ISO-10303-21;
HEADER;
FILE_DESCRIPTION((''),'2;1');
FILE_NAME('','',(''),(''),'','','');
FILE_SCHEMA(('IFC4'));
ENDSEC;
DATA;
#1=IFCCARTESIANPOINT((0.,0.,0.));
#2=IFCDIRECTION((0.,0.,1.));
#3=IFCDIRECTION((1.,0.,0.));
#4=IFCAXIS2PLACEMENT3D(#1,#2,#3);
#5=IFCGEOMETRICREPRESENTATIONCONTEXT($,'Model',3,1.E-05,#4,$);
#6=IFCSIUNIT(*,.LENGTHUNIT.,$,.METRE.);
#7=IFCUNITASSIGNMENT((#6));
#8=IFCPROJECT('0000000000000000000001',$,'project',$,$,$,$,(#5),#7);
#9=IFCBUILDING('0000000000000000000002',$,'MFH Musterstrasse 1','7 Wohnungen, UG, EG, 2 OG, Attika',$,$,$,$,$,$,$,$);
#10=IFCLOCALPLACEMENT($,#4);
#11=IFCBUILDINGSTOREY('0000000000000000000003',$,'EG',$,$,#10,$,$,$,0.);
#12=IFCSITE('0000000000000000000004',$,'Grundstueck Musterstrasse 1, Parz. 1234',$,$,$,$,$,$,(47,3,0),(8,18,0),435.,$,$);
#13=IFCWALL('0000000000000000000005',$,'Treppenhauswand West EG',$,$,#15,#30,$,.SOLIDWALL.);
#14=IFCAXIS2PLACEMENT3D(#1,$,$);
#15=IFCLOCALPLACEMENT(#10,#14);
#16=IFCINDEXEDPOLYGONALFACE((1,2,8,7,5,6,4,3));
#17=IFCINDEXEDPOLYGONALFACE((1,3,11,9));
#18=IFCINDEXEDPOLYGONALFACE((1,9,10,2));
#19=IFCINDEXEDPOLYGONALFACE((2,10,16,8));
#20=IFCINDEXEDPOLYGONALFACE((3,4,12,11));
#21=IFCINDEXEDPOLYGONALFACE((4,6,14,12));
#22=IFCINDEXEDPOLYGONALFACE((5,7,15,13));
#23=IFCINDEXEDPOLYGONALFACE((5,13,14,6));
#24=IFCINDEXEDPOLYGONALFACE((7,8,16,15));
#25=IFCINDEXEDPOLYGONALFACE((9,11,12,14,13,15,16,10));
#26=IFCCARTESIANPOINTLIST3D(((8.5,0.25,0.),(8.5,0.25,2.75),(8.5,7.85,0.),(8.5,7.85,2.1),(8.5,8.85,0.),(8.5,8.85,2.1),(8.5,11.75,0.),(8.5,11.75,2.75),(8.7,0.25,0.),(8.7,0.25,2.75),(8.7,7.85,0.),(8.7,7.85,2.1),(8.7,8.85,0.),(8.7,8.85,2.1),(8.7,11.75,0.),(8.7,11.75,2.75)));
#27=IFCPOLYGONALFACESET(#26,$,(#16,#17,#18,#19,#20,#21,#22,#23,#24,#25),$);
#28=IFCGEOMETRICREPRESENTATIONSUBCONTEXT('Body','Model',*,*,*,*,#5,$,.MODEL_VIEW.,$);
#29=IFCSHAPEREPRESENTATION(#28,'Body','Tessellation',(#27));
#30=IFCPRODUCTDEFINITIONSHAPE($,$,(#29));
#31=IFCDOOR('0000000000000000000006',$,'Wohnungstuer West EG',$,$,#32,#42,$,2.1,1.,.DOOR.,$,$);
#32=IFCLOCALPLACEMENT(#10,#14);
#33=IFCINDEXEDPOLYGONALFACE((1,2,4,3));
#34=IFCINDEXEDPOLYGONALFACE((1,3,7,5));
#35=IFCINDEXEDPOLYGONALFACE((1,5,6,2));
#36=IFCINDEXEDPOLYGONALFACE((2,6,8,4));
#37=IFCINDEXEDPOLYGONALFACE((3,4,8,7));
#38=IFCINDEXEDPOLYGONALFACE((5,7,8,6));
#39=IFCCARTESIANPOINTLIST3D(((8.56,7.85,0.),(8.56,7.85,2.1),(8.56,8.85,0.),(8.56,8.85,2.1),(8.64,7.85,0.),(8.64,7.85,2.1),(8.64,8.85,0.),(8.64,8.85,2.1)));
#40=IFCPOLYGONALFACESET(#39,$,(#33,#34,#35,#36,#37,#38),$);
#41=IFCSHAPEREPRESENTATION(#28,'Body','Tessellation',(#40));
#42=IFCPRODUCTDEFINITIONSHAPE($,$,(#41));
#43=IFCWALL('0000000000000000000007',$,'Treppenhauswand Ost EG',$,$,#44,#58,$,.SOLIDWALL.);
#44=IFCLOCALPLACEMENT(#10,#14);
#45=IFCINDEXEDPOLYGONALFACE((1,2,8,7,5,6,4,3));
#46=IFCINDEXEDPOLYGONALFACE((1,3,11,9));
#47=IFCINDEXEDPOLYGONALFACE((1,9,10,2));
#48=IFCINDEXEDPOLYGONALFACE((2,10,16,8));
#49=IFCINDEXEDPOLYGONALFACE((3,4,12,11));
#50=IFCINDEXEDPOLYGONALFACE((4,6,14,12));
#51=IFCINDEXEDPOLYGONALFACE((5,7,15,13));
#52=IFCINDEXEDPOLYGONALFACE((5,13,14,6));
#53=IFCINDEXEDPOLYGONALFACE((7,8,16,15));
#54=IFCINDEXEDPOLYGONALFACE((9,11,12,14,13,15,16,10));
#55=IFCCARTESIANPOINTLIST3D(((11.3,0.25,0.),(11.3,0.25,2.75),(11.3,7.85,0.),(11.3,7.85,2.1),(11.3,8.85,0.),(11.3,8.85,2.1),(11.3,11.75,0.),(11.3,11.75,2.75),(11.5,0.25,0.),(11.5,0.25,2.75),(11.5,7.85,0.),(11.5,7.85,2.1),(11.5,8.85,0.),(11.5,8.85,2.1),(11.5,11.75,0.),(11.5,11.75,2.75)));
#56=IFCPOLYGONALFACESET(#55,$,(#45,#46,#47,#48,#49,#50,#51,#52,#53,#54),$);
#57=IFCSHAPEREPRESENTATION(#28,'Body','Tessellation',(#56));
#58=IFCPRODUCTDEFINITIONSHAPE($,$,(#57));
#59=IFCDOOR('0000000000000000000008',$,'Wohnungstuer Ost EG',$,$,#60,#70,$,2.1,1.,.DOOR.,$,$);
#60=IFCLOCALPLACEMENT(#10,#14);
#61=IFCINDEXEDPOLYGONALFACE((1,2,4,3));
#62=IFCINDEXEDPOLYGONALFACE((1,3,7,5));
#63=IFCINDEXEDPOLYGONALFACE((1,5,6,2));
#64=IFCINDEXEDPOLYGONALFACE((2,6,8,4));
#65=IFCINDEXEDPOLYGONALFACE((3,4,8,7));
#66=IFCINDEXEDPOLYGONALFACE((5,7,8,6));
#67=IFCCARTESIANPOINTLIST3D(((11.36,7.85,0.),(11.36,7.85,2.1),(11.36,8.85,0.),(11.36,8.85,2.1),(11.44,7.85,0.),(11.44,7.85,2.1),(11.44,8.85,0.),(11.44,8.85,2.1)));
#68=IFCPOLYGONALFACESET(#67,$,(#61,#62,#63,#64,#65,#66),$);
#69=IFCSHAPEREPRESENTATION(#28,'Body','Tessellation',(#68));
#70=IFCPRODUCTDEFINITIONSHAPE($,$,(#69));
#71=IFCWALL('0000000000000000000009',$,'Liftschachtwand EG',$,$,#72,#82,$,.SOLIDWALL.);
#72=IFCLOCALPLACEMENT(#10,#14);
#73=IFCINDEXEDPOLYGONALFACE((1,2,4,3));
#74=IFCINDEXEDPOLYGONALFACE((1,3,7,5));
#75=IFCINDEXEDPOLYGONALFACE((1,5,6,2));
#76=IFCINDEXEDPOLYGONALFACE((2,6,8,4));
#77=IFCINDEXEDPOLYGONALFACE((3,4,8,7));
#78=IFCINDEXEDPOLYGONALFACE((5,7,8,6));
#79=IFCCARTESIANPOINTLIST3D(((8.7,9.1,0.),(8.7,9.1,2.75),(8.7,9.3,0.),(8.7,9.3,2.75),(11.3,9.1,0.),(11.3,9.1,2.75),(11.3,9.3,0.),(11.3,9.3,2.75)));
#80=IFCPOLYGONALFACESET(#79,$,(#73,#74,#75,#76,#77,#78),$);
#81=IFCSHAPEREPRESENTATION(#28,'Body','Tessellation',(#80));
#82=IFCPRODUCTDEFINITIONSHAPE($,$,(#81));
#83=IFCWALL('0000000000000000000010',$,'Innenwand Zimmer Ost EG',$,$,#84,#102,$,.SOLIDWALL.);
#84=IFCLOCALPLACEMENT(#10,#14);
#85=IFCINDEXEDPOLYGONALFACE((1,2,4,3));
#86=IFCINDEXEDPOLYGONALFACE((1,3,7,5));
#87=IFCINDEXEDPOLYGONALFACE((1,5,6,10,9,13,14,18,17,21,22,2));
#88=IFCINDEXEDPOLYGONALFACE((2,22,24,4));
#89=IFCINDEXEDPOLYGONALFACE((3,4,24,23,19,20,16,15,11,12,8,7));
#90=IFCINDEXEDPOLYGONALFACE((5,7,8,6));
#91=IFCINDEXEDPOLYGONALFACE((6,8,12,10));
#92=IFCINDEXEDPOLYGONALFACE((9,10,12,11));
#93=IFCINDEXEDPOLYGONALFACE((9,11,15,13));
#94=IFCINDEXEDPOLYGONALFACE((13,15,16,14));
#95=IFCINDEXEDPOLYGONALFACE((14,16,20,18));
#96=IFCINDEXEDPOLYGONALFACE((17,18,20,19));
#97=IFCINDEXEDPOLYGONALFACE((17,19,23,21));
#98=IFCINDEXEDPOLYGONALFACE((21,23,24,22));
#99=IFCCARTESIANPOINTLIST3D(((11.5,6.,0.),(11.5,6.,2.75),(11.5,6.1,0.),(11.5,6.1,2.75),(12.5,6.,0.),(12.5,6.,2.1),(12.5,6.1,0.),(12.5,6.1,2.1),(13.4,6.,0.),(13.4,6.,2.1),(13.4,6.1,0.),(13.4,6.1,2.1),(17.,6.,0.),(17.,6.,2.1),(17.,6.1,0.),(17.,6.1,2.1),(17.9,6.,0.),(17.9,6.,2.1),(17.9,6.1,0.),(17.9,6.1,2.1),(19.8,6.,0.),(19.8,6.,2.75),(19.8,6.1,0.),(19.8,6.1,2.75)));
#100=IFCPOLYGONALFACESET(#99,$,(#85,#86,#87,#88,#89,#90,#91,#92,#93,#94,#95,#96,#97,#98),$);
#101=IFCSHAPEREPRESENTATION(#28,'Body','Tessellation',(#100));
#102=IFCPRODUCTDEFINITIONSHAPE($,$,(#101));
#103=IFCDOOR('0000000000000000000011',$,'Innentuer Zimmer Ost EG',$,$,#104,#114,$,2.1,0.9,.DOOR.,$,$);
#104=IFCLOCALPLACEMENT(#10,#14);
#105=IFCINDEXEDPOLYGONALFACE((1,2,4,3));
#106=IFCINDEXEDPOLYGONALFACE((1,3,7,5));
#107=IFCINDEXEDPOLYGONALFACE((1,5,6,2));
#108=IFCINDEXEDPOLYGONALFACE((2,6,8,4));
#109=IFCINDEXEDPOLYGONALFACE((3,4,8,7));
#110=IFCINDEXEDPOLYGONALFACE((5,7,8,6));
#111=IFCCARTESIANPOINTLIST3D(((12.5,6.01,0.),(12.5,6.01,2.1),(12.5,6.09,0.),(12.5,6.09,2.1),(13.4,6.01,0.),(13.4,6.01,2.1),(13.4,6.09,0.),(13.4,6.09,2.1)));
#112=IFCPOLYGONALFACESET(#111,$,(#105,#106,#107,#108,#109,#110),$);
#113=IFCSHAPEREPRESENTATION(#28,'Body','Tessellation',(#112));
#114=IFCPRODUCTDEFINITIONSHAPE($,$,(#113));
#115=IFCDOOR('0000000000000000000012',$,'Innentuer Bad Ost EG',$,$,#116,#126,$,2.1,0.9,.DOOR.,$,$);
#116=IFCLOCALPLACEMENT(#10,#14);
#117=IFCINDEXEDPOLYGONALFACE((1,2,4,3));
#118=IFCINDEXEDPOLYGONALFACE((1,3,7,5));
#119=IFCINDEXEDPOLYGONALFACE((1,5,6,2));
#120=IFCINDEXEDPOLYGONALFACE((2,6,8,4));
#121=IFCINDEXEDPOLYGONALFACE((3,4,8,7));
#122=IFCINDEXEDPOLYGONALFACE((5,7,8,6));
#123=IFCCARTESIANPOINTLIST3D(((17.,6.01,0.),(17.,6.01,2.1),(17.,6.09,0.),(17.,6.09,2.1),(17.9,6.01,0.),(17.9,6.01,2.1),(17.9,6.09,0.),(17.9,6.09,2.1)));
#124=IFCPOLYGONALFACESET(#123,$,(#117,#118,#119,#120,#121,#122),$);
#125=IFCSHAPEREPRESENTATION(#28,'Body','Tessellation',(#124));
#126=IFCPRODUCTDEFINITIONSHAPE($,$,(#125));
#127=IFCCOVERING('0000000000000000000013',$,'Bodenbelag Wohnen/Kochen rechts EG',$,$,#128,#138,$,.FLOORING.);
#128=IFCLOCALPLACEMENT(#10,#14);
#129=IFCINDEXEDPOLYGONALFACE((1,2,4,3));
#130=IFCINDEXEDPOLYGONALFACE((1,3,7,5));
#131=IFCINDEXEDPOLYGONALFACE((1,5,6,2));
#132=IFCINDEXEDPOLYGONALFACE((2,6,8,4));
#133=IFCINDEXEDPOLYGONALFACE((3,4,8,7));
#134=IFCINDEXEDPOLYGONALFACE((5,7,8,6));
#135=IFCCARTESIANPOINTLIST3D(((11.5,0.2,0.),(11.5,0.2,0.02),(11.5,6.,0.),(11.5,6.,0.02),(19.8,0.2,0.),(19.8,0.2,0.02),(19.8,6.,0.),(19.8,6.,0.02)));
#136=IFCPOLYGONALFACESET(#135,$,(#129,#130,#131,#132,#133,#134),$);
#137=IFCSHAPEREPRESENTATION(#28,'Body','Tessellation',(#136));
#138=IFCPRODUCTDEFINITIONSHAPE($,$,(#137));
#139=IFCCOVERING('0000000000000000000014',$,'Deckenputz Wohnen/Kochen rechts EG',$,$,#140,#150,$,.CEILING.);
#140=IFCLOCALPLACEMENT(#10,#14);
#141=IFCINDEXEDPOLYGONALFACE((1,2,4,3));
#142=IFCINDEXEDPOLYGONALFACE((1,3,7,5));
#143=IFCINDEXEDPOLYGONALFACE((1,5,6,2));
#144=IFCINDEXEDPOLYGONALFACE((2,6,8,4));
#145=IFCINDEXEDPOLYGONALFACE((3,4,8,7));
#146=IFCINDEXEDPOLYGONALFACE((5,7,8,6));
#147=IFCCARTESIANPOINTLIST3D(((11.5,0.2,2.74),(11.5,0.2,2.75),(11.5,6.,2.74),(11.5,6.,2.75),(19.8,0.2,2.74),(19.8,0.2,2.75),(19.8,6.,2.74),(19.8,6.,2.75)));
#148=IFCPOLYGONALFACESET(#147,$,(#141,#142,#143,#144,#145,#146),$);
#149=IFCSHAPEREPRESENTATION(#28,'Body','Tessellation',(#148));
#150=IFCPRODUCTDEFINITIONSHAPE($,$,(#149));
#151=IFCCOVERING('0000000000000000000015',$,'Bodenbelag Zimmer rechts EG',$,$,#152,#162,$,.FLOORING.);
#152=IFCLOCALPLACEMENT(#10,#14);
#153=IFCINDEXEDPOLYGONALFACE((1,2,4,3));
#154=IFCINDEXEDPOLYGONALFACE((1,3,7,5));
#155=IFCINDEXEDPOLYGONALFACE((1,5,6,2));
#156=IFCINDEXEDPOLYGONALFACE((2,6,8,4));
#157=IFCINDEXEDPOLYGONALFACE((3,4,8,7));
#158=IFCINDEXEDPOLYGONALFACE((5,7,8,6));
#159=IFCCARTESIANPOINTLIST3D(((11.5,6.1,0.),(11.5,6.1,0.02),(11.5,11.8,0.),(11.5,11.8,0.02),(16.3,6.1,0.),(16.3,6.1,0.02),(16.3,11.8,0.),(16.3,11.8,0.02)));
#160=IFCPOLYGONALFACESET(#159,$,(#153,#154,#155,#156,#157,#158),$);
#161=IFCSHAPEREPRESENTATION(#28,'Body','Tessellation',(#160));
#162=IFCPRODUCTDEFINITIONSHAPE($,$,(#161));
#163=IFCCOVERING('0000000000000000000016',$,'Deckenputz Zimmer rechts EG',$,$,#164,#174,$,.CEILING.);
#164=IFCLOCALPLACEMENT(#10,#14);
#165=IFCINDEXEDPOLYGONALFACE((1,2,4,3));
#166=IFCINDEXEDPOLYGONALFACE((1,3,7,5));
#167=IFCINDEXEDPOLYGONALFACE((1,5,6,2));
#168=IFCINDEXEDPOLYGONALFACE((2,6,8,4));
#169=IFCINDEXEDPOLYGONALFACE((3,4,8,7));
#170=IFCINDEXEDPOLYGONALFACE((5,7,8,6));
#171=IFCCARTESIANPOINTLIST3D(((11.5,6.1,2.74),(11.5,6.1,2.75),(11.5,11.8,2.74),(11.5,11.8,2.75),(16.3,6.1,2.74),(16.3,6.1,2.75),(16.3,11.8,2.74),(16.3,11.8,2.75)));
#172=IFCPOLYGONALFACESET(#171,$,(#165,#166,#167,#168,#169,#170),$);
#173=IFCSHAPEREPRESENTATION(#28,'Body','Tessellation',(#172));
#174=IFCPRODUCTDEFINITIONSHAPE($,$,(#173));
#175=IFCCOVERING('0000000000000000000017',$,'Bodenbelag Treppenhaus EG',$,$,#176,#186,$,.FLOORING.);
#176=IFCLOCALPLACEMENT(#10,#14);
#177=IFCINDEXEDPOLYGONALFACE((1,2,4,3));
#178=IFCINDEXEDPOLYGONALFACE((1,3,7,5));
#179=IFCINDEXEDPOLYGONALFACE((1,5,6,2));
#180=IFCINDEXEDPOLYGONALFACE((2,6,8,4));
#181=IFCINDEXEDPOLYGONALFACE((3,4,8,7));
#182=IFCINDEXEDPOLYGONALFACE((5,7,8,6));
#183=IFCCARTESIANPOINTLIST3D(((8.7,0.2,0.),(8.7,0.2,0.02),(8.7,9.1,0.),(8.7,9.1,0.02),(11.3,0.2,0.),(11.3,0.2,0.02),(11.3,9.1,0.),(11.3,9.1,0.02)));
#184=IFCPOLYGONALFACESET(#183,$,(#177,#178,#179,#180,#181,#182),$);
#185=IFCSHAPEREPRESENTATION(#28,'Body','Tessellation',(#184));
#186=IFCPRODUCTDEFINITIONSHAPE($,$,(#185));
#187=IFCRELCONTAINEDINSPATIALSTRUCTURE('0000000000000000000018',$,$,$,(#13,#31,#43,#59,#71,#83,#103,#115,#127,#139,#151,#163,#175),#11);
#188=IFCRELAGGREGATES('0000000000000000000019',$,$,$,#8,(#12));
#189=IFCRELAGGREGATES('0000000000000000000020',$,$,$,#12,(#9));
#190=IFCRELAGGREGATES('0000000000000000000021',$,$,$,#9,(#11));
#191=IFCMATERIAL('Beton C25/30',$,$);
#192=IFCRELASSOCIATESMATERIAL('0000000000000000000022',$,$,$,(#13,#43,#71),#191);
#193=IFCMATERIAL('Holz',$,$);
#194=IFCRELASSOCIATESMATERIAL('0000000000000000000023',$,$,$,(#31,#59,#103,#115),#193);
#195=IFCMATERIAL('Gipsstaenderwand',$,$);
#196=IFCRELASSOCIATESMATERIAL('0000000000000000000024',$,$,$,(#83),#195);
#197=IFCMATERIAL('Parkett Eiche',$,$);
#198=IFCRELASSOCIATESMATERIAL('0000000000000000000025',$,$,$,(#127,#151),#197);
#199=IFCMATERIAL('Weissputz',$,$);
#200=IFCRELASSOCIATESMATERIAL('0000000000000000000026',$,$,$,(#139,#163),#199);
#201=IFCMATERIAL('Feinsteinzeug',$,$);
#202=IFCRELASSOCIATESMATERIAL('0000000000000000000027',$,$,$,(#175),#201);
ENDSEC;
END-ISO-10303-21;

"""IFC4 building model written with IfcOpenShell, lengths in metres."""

from ifc_helpers import new_model, si_unit, frame, frame_2d, origin_with_axes, place, context, subcontext, project, spatial, rectangle, extrude, material, element, fill, save


model = new_model("IFC4")

# Units and contexts
model_context = context("Model", 3, precision=1e-05, world=origin_with_axes())
body_context = subcontext(model_context, "Body", "Model", "MODEL_VIEW")
ifc_project = project(units=[si_unit("LENGTHUNIT", "METRE")], contexts=[model_context])

# Site, building, storey
site = spatial("IfcSite", under=ifc_project, Name="Grundstueck Musterstrasse 1, Parz. 1234", RefLatitude=(47, 3, 0), RefLongitude=(8, 18, 0), RefElevation=435.0)
building = spatial("IfcBuilding", under=site, Name="MFH Musterstrasse 1", Description="7 Wohnungen, UG, EG, 2 OG, Attika")
storey_placement = place(None, origin_with_axes())
storey = spatial("IfcBuildingStorey", under=building, at=storey_placement, Name="EG", Elevation=0.0)

# Walls, openings, doors
ifc_material_1 = material(Name="Beton C25/30")
wall_1_placement = place(storey_placement, frame((8.5, 0.25, 0.0), z_axis=(0.0, 0.0, 1.0), x_axis=(1.0, 0.0, 0.0)))
wall_1 = element("IfcWall", 1, at=wall_1_placement, inside=storey, material=ifc_material_1, Name="Treppenhauswand West EG", PredefinedType="SOLIDWALL", context=body_context, shape_type="SweptSolid", body=[
    extrude(rectangle(XDim=0.2, YDim=11.5, at=frame_2d((0.1, 5.75))), origin_with_axes(), (0.0, 0.0, 1.0), 2.75),
])
opening_1_placement = place(wall_1_placement, frame((-0.01, 7.6, 0.0), z_axis=(0.0, 0.0, 1.0), x_axis=(1.0, 0.0, 0.0)))
opening_1 = element("IfcOpeningElement", 2, at=opening_1_placement, cuts=wall_1, context=body_context, shape_type="SweptSolid", body=[
    extrude(rectangle(XDim=0.22, YDim=1.0, at=frame_2d((0.11, 0.5))), origin_with_axes(), (0.0, 0.0, 1.0), 2.1),
])
ifc_material_2 = material(Name="Holz")
door_1_placement = place(storey_placement, frame((8.56, 7.85, 0.0), z_axis=(0.0, 0.0, 1.0), x_axis=(1.0, 0.0, 0.0)))
door_1 = element("IfcDoor", 3, at=door_1_placement, inside=storey, material=ifc_material_2, Name="Wohnungstuer West EG", OverallHeight=2.1, OverallWidth=1.0, PredefinedType="DOOR", context=body_context, shape_type="SweptSolid", body=[
    extrude(rectangle(XDim=0.08, YDim=1.0, at=frame_2d((0.04, 0.5))), origin_with_axes(), (0.0, 0.0, 1.0), 2.1),
])
fill(opening_1, door_1)
wall_2_placement = place(storey_placement, frame((11.3, 0.25, 0.0), z_axis=(0.0, 0.0, 1.0), x_axis=(1.0, 0.0, 0.0)))
wall_2 = element("IfcWall", 4, at=wall_2_placement, inside=storey, material=ifc_material_1, Name="Treppenhauswand Ost EG", PredefinedType="SOLIDWALL", context=body_context, shape_type="SweptSolid", body=[
    extrude(rectangle(XDim=0.2, YDim=11.5, at=frame_2d((0.1, 5.75))), origin_with_axes(), (0.0, 0.0, 1.0), 2.75),
])
opening_2_placement = place(wall_2_placement, frame((-0.01, 7.6, 0.0), z_axis=(0.0, 0.0, 1.0), x_axis=(1.0, 0.0, 0.0)))
opening_2 = element("IfcOpeningElement", 5, at=opening_2_placement, cuts=wall_2, context=body_context, shape_type="SweptSolid", body=[
    extrude(rectangle(XDim=0.22, YDim=1.0, at=frame_2d((0.11, 0.5))), origin_with_axes(), (0.0, 0.0, 1.0), 2.1),
])
door_2_placement = place(storey_placement, frame((11.36, 7.85, 0.0), z_axis=(0.0, 0.0, 1.0), x_axis=(1.0, 0.0, 0.0)))
door_2 = element("IfcDoor", 6, at=door_2_placement, inside=storey, material=ifc_material_2, Name="Wohnungstuer Ost EG", OverallHeight=2.1, OverallWidth=1.0, PredefinedType="DOOR", context=body_context, shape_type="SweptSolid", body=[
    extrude(rectangle(XDim=0.08, YDim=1.0, at=frame_2d((0.04, 0.5))), origin_with_axes(), (0.0, 0.0, 1.0), 2.1),
])
fill(opening_2, door_2)

# Wall
wall_3_placement = place(storey_placement, frame((8.7, 9.1, 0.0), z_axis=(0.0, 0.0, 1.0), x_axis=(1.0, 0.0, 0.0)))
element("IfcWall", 7, at=wall_3_placement, inside=storey, material=ifc_material_1, Name="Liftschachtwand EG", PredefinedType="SOLIDWALL", context=body_context, shape_type="SweptSolid", body=[
    extrude(rectangle(XDim=2.6, YDim=0.2, at=frame_2d((1.3, 0.1))), origin_with_axes(), (0.0, 0.0, 1.0), 2.75),
])

# Wall, openings, doors
ifc_material_3 = material(Name="Gipsstaenderwand")
wall_4_placement = place(storey_placement, frame((11.5, 6.0, 0.0), z_axis=(0.0, 0.0, 1.0), x_axis=(1.0, 0.0, 0.0)))
wall_4 = element("IfcWall", 8, at=wall_4_placement, inside=storey, material=ifc_material_3, Name="Innenwand Zimmer Ost EG", PredefinedType="SOLIDWALL", context=body_context, shape_type="SweptSolid", body=[
    extrude(rectangle(XDim=8.3, YDim=0.1, at=frame_2d((4.15, 0.05))), origin_with_axes(), (0.0, 0.0, 1.0), 2.75),
])
opening_3_placement = place(wall_4_placement, frame((1.0, -0.01, 0.0), z_axis=(0.0, 0.0, 1.0), x_axis=(1.0, 0.0, 0.0)))
opening_3 = element("IfcOpeningElement", 9, at=opening_3_placement, cuts=wall_4, context=body_context, shape_type="SweptSolid", body=[
    extrude(rectangle(XDim=0.9, YDim=0.12, at=frame_2d((0.45, 0.06))), origin_with_axes(), (0.0, 0.0, 1.0), 2.1),
])
opening_4_placement = place(wall_4_placement, frame((5.5, -0.01, 0.0), z_axis=(0.0, 0.0, 1.0), x_axis=(1.0, 0.0, 0.0)))
opening_4 = element("IfcOpeningElement", 10, at=opening_4_placement, cuts=wall_4, context=body_context, shape_type="SweptSolid", body=[
    extrude(rectangle(XDim=0.9, YDim=0.12, at=frame_2d((0.45, 0.06))), origin_with_axes(), (0.0, 0.0, 1.0), 2.1),
])
door_3_placement = place(storey_placement, frame((12.5, 6.01, 0.0), z_axis=(0.0, 0.0, 1.0), x_axis=(1.0, 0.0, 0.0)))
door_3 = element("IfcDoor", 11, at=door_3_placement, inside=storey, material=ifc_material_2, Name="Innentuer Zimmer Ost EG", OverallHeight=2.1, OverallWidth=0.9, PredefinedType="DOOR", context=body_context, shape_type="SweptSolid", body=[
    extrude(rectangle(XDim=0.9, YDim=0.08, at=frame_2d((0.45, 0.04))), origin_with_axes(), (0.0, 0.0, 1.0), 2.1),
])
fill(opening_3, door_3)
door_4_placement = place(storey_placement, frame((17.0, 6.01, 0.0), z_axis=(0.0, 0.0, 1.0), x_axis=(1.0, 0.0, 0.0)))
door_4 = element("IfcDoor", 12, at=door_4_placement, inside=storey, material=ifc_material_2, Name="Innentuer Bad Ost EG", OverallHeight=2.1, OverallWidth=0.9, PredefinedType="DOOR", context=body_context, shape_type="SweptSolid", body=[
    extrude(rectangle(XDim=0.9, YDim=0.08, at=frame_2d((0.45, 0.04))), origin_with_axes(), (0.0, 0.0, 1.0), 2.1),
])
fill(opening_4, door_4)

# Coverings
ifc_material_4 = material(Name="Parkett Eiche")
covering_1_placement = place(storey_placement, frame((11.5, 0.2, 0.0), z_axis=(0.0, 0.0, 1.0), x_axis=(1.0, 0.0, 0.0)))
element("IfcCovering", 13, at=covering_1_placement, inside=storey, material=ifc_material_4, Name="Bodenbelag Wohnen/Kochen rechts EG", PredefinedType="FLOORING", context=body_context, shape_type="SweptSolid", body=[
    extrude(rectangle(XDim=8.3, YDim=5.8, at=frame_2d((4.15, 2.9))), origin_with_axes(), (0.0, 0.0, 1.0), 0.02),
])
ifc_material_5 = material(Name="Weissputz")
covering_2_placement = place(storey_placement, frame((11.5, 0.2, 2.74), z_axis=(0.0, 0.0, 1.0), x_axis=(1.0, 0.0, 0.0)))
element("IfcCovering", 14, at=covering_2_placement, inside=storey, material=ifc_material_5, Name="Deckenputz Wohnen/Kochen rechts EG", PredefinedType="CEILING", context=body_context, shape_type="SweptSolid", body=[
    extrude(rectangle(XDim=8.3, YDim=5.8, at=frame_2d((4.15, 2.9))), origin_with_axes(), (0.0, 0.0, 1.0), 0.01),
])
covering_3_placement = place(storey_placement, frame((11.5, 6.1, 0.0), z_axis=(0.0, 0.0, 1.0), x_axis=(1.0, 0.0, 0.0)))
element("IfcCovering", 15, at=covering_3_placement, inside=storey, material=ifc_material_4, Name="Bodenbelag Zimmer rechts EG", PredefinedType="FLOORING", context=body_context, shape_type="SweptSolid", body=[
    extrude(rectangle(XDim=4.8, YDim=5.7, at=frame_2d((2.4, 2.85))), origin_with_axes(), (0.0, 0.0, 1.0), 0.02),
])
covering_4_placement = place(storey_placement, frame((11.5, 6.1, 2.74), z_axis=(0.0, 0.0, 1.0), x_axis=(1.0, 0.0, 0.0)))
element("IfcCovering", 16, at=covering_4_placement, inside=storey, material=ifc_material_5, Name="Deckenputz Zimmer rechts EG", PredefinedType="CEILING", context=body_context, shape_type="SweptSolid", body=[
    extrude(rectangle(XDim=4.8, YDim=5.7, at=frame_2d((2.4, 2.85))), origin_with_axes(), (0.0, 0.0, 1.0), 0.01),
])
ifc_material_6 = material(Name="Feinsteinzeug")
covering_5_placement = place(storey_placement, frame((8.7, 0.2, 0.0), z_axis=(0.0, 0.0, 1.0), x_axis=(1.0, 0.0, 0.0)))
element("IfcCovering", 17, at=covering_5_placement, inside=storey, material=ifc_material_6, Name="Bodenbelag Treppenhaus EG", PredefinedType="FLOORING", context=body_context, shape_type="SweptSolid", body=[
    extrude(rectangle(XDim=2.6, YDim=8.9, at=frame_2d((1.3, 4.45))), origin_with_axes(), (0.0, 0.0, 1.0), 0.02),
])

save(model, "model.ifc")
